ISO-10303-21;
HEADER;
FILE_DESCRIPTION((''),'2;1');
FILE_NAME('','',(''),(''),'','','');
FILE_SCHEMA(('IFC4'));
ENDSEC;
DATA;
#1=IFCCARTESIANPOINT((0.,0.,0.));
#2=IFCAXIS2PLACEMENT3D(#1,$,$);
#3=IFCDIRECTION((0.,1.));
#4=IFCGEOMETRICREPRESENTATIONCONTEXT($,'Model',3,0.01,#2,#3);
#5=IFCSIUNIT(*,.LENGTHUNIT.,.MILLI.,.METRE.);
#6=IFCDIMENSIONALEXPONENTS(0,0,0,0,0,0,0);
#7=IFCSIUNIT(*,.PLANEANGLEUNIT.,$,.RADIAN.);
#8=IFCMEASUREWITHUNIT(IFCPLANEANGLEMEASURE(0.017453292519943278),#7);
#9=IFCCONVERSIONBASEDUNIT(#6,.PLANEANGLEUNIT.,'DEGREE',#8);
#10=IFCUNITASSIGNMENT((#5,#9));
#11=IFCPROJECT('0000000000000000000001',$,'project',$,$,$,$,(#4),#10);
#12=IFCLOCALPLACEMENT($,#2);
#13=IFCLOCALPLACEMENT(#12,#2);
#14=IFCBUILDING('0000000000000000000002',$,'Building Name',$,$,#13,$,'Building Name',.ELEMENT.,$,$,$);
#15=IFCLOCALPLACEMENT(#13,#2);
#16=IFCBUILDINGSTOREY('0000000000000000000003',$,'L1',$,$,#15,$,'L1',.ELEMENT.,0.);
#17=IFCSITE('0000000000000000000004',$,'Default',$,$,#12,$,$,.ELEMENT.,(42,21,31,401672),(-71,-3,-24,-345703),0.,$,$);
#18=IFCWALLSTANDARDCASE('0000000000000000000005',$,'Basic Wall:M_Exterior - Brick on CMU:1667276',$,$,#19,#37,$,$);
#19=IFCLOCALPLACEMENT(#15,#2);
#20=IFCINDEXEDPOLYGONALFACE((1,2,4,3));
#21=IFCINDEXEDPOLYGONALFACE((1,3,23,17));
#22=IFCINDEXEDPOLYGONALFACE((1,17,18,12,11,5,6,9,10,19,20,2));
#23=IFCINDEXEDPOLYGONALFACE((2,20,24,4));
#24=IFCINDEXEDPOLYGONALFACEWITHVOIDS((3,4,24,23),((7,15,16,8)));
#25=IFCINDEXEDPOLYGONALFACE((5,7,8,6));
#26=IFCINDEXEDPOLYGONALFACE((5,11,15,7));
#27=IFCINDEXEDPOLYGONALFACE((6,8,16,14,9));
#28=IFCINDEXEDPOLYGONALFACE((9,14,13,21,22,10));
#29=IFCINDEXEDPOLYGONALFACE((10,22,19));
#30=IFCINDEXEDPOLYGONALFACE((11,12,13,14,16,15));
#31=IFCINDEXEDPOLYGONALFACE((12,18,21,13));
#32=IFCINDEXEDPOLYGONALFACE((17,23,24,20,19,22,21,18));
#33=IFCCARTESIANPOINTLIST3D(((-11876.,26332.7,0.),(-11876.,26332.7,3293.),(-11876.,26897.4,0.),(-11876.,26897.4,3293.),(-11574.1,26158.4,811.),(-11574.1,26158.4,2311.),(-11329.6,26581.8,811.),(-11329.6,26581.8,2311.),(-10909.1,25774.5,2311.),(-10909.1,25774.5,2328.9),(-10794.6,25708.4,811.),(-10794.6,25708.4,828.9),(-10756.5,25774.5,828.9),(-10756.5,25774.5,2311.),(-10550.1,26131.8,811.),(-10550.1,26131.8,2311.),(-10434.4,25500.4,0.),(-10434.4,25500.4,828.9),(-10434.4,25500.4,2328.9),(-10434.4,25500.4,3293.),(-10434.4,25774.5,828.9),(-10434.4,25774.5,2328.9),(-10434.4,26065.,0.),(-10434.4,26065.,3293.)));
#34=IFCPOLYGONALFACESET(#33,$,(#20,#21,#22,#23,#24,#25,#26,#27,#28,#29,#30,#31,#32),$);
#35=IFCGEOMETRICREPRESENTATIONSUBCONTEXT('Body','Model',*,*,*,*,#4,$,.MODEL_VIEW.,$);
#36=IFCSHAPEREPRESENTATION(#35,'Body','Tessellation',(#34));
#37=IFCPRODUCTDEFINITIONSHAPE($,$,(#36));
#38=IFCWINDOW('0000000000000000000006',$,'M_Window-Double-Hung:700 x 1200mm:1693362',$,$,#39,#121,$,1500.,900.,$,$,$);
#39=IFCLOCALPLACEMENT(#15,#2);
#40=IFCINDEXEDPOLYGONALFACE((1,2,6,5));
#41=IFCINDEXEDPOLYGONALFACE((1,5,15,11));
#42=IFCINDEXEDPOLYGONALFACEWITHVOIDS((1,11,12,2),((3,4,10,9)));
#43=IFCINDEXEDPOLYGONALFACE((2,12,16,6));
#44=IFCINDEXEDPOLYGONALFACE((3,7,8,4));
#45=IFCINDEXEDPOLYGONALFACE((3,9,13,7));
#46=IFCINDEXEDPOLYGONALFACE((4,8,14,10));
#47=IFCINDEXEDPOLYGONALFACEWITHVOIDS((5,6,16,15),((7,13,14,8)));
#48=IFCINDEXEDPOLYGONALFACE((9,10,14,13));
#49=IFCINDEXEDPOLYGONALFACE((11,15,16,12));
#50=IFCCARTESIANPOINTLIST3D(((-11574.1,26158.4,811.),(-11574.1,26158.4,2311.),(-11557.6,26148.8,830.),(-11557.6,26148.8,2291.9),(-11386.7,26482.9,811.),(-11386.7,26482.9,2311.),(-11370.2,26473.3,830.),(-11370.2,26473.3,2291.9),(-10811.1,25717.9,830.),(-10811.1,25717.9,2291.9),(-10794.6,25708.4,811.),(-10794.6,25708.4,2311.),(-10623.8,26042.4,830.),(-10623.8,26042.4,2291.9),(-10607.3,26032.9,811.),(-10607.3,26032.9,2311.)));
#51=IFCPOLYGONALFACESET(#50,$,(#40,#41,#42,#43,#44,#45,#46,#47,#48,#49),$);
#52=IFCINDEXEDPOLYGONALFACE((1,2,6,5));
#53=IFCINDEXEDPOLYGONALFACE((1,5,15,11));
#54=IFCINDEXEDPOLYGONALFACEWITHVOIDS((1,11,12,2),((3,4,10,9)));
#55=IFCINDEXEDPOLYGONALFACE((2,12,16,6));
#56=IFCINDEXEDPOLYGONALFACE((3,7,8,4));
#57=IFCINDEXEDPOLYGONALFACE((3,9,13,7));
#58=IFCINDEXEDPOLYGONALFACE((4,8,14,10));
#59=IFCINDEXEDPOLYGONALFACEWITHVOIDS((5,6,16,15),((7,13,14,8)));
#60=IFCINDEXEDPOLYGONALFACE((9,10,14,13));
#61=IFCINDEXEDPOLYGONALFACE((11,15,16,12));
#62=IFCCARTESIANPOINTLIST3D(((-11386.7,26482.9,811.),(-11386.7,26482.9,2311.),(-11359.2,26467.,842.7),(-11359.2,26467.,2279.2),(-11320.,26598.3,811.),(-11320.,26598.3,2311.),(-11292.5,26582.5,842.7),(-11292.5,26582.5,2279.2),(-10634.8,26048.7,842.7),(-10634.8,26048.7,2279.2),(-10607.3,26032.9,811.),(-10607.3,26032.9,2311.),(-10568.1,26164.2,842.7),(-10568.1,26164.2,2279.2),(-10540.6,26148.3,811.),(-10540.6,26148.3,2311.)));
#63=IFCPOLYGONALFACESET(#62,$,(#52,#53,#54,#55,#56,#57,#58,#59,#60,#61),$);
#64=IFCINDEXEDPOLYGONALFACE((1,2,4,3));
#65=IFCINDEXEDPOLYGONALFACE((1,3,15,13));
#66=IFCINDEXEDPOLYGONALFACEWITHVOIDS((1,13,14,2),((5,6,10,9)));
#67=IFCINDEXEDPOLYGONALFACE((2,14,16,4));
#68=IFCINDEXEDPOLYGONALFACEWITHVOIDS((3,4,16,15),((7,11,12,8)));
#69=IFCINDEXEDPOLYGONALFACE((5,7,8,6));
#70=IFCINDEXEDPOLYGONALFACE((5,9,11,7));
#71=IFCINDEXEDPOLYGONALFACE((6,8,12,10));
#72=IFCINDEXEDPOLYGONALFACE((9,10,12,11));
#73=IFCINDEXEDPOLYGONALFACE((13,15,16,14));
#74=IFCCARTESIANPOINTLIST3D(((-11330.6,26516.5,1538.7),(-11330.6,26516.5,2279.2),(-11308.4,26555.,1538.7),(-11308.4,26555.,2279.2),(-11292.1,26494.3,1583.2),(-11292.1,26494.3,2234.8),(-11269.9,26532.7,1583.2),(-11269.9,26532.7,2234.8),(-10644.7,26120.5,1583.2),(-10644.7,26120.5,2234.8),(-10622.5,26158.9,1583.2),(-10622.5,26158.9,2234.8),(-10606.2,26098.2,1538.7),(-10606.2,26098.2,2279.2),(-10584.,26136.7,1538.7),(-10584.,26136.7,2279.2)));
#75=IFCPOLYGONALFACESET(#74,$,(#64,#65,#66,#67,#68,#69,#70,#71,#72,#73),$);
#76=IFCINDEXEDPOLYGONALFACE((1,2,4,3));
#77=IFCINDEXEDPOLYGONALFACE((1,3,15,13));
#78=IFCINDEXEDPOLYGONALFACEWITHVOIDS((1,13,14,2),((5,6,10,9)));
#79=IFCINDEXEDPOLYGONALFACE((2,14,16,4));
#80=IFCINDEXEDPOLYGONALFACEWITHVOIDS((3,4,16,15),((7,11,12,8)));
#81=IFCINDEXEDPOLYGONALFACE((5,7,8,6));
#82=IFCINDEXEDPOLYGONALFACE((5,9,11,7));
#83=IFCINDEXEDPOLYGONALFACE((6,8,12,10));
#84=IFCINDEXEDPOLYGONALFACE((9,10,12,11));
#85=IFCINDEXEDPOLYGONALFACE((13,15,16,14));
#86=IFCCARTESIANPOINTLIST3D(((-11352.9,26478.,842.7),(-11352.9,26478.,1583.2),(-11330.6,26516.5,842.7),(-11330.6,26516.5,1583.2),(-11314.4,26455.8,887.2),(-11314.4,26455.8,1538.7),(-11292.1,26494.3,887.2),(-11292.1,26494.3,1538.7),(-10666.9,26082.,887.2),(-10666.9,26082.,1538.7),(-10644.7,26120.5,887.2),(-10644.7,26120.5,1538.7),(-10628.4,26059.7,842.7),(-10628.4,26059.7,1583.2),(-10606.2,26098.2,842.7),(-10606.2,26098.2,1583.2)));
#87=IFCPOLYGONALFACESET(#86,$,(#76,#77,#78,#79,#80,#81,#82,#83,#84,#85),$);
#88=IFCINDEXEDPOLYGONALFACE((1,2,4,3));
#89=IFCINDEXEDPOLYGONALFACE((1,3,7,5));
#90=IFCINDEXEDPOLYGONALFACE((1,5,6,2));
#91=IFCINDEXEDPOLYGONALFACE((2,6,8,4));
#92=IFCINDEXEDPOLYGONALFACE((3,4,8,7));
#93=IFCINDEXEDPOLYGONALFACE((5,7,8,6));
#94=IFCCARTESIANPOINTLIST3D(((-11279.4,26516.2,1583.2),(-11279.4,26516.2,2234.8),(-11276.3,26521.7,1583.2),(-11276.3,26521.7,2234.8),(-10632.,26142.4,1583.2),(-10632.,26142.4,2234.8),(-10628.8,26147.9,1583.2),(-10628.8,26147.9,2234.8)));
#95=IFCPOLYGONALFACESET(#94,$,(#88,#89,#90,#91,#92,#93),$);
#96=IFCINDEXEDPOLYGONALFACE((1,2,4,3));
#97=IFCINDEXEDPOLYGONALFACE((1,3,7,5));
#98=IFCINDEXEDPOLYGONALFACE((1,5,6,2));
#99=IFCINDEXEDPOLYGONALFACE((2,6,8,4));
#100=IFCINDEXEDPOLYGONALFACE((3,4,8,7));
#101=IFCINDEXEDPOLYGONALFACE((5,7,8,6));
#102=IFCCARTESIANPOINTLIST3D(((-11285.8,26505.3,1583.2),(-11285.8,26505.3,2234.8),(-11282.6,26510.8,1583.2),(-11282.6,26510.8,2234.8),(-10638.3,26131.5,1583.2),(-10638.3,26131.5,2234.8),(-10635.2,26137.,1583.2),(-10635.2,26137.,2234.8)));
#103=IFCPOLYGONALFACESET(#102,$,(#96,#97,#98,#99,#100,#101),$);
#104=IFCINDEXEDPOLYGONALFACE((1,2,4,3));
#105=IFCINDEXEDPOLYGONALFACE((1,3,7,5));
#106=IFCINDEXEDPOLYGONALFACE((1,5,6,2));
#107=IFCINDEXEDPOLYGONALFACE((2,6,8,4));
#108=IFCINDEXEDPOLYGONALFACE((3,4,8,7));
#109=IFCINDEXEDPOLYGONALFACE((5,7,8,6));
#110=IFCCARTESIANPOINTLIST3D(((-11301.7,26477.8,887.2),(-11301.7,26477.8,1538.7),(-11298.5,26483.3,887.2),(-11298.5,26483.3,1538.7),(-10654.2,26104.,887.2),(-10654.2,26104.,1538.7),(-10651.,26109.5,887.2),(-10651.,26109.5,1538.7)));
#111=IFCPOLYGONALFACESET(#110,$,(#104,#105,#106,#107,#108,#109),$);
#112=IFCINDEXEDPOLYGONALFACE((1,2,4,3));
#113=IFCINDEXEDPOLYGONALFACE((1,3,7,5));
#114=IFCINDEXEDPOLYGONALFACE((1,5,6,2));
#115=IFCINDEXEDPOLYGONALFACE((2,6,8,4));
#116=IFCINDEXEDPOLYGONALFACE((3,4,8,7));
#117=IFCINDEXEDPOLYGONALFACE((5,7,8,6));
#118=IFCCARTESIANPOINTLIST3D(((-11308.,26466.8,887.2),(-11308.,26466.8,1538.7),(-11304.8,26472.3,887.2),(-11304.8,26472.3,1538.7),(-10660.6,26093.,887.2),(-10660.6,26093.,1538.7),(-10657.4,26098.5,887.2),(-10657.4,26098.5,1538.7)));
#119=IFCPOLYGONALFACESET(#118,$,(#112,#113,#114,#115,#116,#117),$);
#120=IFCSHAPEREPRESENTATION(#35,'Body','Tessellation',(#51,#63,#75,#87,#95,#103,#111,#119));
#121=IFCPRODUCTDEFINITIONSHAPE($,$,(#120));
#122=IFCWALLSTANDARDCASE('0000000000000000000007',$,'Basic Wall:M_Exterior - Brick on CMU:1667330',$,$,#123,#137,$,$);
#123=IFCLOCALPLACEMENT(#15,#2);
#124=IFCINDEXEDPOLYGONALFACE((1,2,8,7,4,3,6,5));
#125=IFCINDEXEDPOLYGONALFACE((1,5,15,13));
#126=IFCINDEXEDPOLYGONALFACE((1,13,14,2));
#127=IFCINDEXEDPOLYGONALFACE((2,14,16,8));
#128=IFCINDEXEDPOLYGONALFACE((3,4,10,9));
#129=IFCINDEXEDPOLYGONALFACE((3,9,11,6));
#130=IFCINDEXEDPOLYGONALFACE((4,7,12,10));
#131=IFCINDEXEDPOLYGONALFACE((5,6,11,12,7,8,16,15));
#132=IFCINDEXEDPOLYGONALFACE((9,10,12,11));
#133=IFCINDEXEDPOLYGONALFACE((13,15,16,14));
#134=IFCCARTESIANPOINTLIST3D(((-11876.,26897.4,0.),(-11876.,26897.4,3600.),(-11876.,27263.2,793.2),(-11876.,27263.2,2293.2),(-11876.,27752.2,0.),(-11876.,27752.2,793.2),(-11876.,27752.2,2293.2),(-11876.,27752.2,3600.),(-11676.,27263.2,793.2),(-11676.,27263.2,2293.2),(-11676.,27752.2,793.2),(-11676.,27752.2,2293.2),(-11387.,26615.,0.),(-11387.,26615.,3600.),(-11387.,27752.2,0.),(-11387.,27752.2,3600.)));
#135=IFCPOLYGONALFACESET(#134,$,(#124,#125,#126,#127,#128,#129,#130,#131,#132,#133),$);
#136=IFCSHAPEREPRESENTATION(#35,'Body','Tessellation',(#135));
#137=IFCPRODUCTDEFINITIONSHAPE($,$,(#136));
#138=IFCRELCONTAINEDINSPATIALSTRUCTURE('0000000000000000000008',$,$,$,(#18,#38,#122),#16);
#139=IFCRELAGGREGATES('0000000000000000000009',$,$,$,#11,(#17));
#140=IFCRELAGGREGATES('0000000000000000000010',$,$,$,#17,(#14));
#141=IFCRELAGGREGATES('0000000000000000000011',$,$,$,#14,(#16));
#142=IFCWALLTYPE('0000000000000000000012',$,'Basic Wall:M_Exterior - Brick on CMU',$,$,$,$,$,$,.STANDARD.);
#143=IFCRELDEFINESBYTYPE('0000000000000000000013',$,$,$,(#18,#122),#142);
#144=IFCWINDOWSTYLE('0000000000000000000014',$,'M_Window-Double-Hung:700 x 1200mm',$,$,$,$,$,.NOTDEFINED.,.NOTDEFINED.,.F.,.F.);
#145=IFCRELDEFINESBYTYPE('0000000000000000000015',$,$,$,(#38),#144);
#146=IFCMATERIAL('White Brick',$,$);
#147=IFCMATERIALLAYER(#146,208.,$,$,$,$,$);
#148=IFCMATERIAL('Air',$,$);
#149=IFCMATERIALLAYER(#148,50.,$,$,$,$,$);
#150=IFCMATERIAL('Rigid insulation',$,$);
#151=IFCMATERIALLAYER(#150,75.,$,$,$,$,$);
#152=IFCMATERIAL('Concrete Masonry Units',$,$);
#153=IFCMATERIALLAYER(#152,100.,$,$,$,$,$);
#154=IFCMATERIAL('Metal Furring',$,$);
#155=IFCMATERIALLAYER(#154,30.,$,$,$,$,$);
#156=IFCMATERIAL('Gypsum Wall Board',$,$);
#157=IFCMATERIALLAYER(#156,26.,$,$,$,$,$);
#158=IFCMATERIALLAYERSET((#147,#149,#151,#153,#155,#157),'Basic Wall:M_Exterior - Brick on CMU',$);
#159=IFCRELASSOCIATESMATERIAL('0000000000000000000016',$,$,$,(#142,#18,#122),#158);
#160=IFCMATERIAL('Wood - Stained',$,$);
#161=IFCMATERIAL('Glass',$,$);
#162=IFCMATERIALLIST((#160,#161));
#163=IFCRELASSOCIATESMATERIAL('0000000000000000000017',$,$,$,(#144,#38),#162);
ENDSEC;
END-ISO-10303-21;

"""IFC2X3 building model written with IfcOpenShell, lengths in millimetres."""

from ifc_helpers import new_model, entity, si_unit, converted_unit, direction, frame, frame_2d, origin, place, context, subcontext, project, spatial, polyline, rectangle, outline, extrude, clip, bounded_halfspace, source, transform, mapped, material, material_list, layer, layer_set, layer_usage, type_object, type_shapes, element, fill, save


model = new_model("IFC2X3")

# Units and contexts
model_context = context("Model", 3, precision=0.01, world=origin(), true_north=direction((0.0, 1.0)))
body_context = subcontext(model_context, "Body", "Model", "MODEL_VIEW")
ifc_project = project(units=[si_unit("LENGTHUNIT", "METRE", prefix="MILLI"), converted_unit("PLANEANGLEUNIT", "DEGREE", entity("IfcPlaneAngleMeasure", 0.017453292519943278), si_unit("PLANEANGLEUNIT", "RADIAN"), dimensions=[0, 0, 0, 0, 0, 0, 0])], contexts=[model_context])

# Site, building, storey
site_placement = place(None, origin())
site = spatial("IfcSite", under=ifc_project, at=site_placement, Name="Default", CompositionType="ELEMENT", RefLatitude=(42, 21, 31, 401672), RefLongitude=(-71, -3, -24, -345703), RefElevation=0.0)
building_placement = place(site_placement, origin())
building = spatial("IfcBuilding", under=site, at=building_placement, Name="Building Name", LongName="Building Name", CompositionType="ELEMENT")
storey_placement = place(building_placement, origin())
storey = spatial("IfcBuildingStorey", under=building, at=storey_placement, Name="L1", LongName="L1", CompositionType="ELEMENT", Elevation=0.0)

# Wall, openings, window
ifc_material_1 = material(Name="White Brick")
ifc_layer_1 = layer(ifc_material_1, 208.0)
ifc_material_2 = material(Name="Air")
ifc_layer_2 = layer(ifc_material_2, 50.0)
ifc_material_3 = material(Name="Rigid insulation")
ifc_layer_3 = layer(ifc_material_3, 75.0)
ifc_material_4 = material(Name="Concrete Masonry Units")
ifc_layer_4 = layer(ifc_material_4, 100.0)
ifc_material_5 = material(Name="Metal Furring")
ifc_layer_5 = layer(ifc_material_5, 30.0)
ifc_material_6 = material(Name="Gypsum Wall Board")
ifc_layer_6 = layer(ifc_material_6, 26.0)
ifc_layer_set = layer_set([ifc_layer_1, ifc_layer_2, ifc_layer_3, ifc_layer_4, ifc_layer_5, ifc_layer_6], Name="Basic Wall:M_Exterior - Brick on CMU")
ifc_layer_usage_1 = layer_usage(ifc_layer_set, "AXIS2", "POSITIVE", -244.5)
wall_type = type_object("IfcWallType", Name="Basic Wall:M_Exterior - Brick on CMU", PredefinedType="STANDARD", material=ifc_layer_set)
wall_1_placement = place(storey_placement, frame((-10312.2, 25712.1, 0.0), z_axis=(0.0, 0.0, 1.0), x_axis=(-0.866025, 0.5, 0.0)))
wall_1 = element("IfcWallStandardCase", 1, at=wall_1_placement, inside=storey, type_object=wall_type, material=ifc_layer_usage_1, Name="Basic Wall:M_Exterior - Brick on CMU:1667276", context=body_context, shape_type="Clipping", body=[
    clip(extrude(outline(polyline([(1947.0, -244.5), (1664.6, 244.5), (564.6, 244.5), (0.0, 244.5), (282.3, -244.5), (1382.3, -244.5), (1947.0, -244.5)])), origin(), (0.0, 0.0, 1.0), 3293.0), bounded_halfspace(frame((282.3, -244.5, 3293.0), z_axis=(0.0, 0.0, -1.0), x_axis=(-0.5, 0.866025, 0.0)), True, frame((282.3, -244.5, 3293.0)), polyline([(0.0, 0.0), (1664.6, 0.0), (1382.3, 489.0), (282.3, 489.0), (-282.3, 489.0), (0.0, 0.0)]))),
])
opening_1_placement = place(wall_1_placement, origin())
element("IfcOpeningElement", 2, at=opening_1_placement, cuts=wall_1, ObjectType="Opening", context=body_context, shape_type="SweptSolid", body=[
    extrude(rectangle(XDim=1500.0, YDim=489.0, at=frame_2d((0.0, 0.0), x_axis=(0.0, 1.0))), frame((348.8, 129.4, 1578.9), z_axis=(-0.5, 0.866025, 0.0), x_axis=(-0.866025, -0.5, 0.0)), (0.0, 0.0, 1.0), 1200.0),
])
opening_2_placement = place(wall_1_placement, frame((1315.9, 244.5, 811.0)))
opening_2 = element("IfcOpeningElement", 3, at=opening_2_placement, cuts=wall_1, ObjectType="Opening", context=body_context, shape_type="SweptSolid", body=[
    extrude(rectangle(XDim=1500.0, YDim=900.0, at=frame_2d((750.0, 450.0), x_axis=(-1.0, 0.0))), frame((0.0, 0.0, 0.0), z_axis=(0.0, -1.0, 0.0), x_axis=(0.0, 0.0, 1.0)), (0.0, 0.0, 1.0), 489.0),
])
ifc_material_7 = material(Name="Wood - Stained")
ifc_material_8 = material(Name="Glass")
ifc_material_list_1 = material_list([ifc_material_7, ifc_material_8])
window_style_1 = type_object("IfcWindowStyle", Name="M_Window-Double-Hung:700 x 1200mm", ConstructionType="NOTDEFINED", OperationType="NOTDEFINED", ParameterTakesPrecedence=False, Sizeable=False, material=ifc_material_list_1)
shared_shape_1 = source(origin(), body_context, "Body", "SweptSolid", [
    extrude(outline(polyline([(-750.0, -450.0), (750.0, -450.0), (750.0, 450.0), (-750.0, 450.0), (-750.0, -450.0)]), holes=[polyline([(-730.9, -430.9), (-730.9, 430.9), (730.9, 430.9), (730.9, -430.9), (-730.9, -430.9)])]), frame((450.0, 0.0, 750.0), z_axis=(0.0, 1.0, 0.0), x_axis=(0.0, 0.0, -1.0)), (0.0, 0.0, 1.0), 374.7),
    extrude(outline(polyline([(-450.0, -750.0), (450.0, -750.0), (450.0, 750.0), (-450.0, 750.0), (-450.0, -750.0)]), holes=[polyline([(418.2, -718.2), (-418.2, -718.2), (-418.2, 718.2), (418.2, 718.2), (418.2, -718.2)])]), frame((450.0, 374.7, 750.0), z_axis=(0.0, 1.0, 0.0), x_axis=(1.0, 0.0, 0.0)), (0.0, 0.0, 1.0), 133.3),
    extrude(outline(polyline([(-418.2, -370.2), (418.2, -370.2), (418.2, 370.2), (-418.2, 370.2), (-418.2, -370.2)]), holes=[polyline([(373.8, -325.8), (-373.8, -325.8), (-373.8, 325.8), (373.8, 325.8), (373.8, -325.8)])]), frame((450.0, 431.8, 1098.0), z_axis=(0.0, 1.0, 0.0), x_axis=(1.0, 0.0, 0.0)), (0.0, 0.0, 1.0), 44.4),
    extrude(outline(polyline([(-418.2, -370.2), (418.2, -370.2), (418.2, 370.2), (-418.2, 370.2), (-418.2, -370.2)]), holes=[polyline([(373.8, -325.8), (-373.8, -325.8), (-373.8, 325.8), (373.8, 325.8), (373.8, -325.8)])]), frame((450.0, 387.4, 402.0), z_axis=(0.0, 1.0, 0.0), x_axis=(1.0, 0.0, 0.0)), (0.0, 0.0, 1.0), 44.5),
    extrude(rectangle(XDim=747.6, YDim=6.4, at=frame_2d((0.0, 0.0), x_axis=(1.0, 0.0))), frame((450.0, 460.4, 772.2), z_axis=(0.0, 0.0, 1.0), x_axis=(-1.0, 0.0, 0.0)), (0.0, 0.0, 1.0), 651.6),
    extrude(rectangle(XDim=6.4, YDim=747.6, at=frame_2d((0.0, 0.0), x_axis=(1.0, 0.0))), frame((450.0, 447.7, 772.2), z_axis=(0.0, 0.0, 1.0), x_axis=(0.0, -1.0, 0.0)), (0.0, 0.0, 1.0), 651.6),
    extrude(rectangle(XDim=747.6, YDim=6.4, at=frame_2d((0.0, 0.0), x_axis=(1.0, 0.0))), frame((450.0, 416.0, 76.2), z_axis=(0.0, 0.0, 1.0), x_axis=(-1.0, 0.0, 0.0)), (0.0, 0.0, 1.0), 651.6),
    extrude(rectangle(XDim=6.4, YDim=747.6, at=frame_2d((0.0, 0.0), x_axis=(1.0, 0.0))), frame((450.0, 403.3, 76.2), z_axis=(0.0, 0.0, 1.0), x_axis=(0.0, -1.0, 0.0)), (0.0, 0.0, 1.0), 651.6),
])
type_shapes(window_style_1, [shared_shape_1])
window_1_placement = place(opening_2_placement, frame((0.0, 0.0, 0.0), z_axis=(0.0, 0.0, 1.0), x_axis=(-1.0, 0.0, 0.0)))
window_1 = element("IfcWindow", 4, at=window_1_placement, inside=storey, type_object=window_style_1, material=ifc_material_list_1, Name="M_Window-Double-Hung:700 x 1200mm:1693362", OverallHeight=1500.0, OverallWidth=900.0, context=body_context, shape_type="MappedRepresentation", body=[
    mapped(shared_shape_1, transform((0.0, 0.0, 0.0), scale=1.0)),
])
fill(opening_2, window_1)

# Wall, opening
ifc_layer_usage_2 = layer_usage(ifc_layer_set, "AXIS2", "POSITIVE", -244.5)
wall_2_placement = place(storey_placement, frame((-11631.5, 26615.0, 0.0), z_axis=(0.0, 0.0, 1.0), x_axis=(0.0, 1.0, 0.0)))
wall_2 = element("IfcWallStandardCase", 5, at=wall_2_placement, inside=storey, type_object=wall_type, material=ifc_layer_usage_2, Name="Basic Wall:M_Exterior - Brick on CMU:1667330", context=body_context, shape_type="SweptSolid", body=[
    extrude(outline(polyline([(1137.1, -244.5), (1137.1, 244.5), (648.1, 244.5), (282.3, 244.5), (0.0, -244.5), (1137.1, -244.5)])), origin(), (0.0, 0.0, 1.0), 3600.0),
])
opening_3_placement = place(wall_2_placement, origin())
element("IfcOpeningElement", 6, at=opening_3_placement, cuts=wall_2, ObjectType="Opening", context=body_context, shape_type="SweptSolid", body=[
    extrude(rectangle(XDim=1500.0, YDim=489.0, at=frame_2d((0.0, 0.0), x_axis=(0.0, 1.0))), frame((892.6, 44.5, 1543.2), z_axis=(0.0, 1.0, 0.0), x_axis=(1.0, 0.0, 0.0)), (0.0, 0.0, 1.0), 1200.0),
])

save(model, "model.ifc")
